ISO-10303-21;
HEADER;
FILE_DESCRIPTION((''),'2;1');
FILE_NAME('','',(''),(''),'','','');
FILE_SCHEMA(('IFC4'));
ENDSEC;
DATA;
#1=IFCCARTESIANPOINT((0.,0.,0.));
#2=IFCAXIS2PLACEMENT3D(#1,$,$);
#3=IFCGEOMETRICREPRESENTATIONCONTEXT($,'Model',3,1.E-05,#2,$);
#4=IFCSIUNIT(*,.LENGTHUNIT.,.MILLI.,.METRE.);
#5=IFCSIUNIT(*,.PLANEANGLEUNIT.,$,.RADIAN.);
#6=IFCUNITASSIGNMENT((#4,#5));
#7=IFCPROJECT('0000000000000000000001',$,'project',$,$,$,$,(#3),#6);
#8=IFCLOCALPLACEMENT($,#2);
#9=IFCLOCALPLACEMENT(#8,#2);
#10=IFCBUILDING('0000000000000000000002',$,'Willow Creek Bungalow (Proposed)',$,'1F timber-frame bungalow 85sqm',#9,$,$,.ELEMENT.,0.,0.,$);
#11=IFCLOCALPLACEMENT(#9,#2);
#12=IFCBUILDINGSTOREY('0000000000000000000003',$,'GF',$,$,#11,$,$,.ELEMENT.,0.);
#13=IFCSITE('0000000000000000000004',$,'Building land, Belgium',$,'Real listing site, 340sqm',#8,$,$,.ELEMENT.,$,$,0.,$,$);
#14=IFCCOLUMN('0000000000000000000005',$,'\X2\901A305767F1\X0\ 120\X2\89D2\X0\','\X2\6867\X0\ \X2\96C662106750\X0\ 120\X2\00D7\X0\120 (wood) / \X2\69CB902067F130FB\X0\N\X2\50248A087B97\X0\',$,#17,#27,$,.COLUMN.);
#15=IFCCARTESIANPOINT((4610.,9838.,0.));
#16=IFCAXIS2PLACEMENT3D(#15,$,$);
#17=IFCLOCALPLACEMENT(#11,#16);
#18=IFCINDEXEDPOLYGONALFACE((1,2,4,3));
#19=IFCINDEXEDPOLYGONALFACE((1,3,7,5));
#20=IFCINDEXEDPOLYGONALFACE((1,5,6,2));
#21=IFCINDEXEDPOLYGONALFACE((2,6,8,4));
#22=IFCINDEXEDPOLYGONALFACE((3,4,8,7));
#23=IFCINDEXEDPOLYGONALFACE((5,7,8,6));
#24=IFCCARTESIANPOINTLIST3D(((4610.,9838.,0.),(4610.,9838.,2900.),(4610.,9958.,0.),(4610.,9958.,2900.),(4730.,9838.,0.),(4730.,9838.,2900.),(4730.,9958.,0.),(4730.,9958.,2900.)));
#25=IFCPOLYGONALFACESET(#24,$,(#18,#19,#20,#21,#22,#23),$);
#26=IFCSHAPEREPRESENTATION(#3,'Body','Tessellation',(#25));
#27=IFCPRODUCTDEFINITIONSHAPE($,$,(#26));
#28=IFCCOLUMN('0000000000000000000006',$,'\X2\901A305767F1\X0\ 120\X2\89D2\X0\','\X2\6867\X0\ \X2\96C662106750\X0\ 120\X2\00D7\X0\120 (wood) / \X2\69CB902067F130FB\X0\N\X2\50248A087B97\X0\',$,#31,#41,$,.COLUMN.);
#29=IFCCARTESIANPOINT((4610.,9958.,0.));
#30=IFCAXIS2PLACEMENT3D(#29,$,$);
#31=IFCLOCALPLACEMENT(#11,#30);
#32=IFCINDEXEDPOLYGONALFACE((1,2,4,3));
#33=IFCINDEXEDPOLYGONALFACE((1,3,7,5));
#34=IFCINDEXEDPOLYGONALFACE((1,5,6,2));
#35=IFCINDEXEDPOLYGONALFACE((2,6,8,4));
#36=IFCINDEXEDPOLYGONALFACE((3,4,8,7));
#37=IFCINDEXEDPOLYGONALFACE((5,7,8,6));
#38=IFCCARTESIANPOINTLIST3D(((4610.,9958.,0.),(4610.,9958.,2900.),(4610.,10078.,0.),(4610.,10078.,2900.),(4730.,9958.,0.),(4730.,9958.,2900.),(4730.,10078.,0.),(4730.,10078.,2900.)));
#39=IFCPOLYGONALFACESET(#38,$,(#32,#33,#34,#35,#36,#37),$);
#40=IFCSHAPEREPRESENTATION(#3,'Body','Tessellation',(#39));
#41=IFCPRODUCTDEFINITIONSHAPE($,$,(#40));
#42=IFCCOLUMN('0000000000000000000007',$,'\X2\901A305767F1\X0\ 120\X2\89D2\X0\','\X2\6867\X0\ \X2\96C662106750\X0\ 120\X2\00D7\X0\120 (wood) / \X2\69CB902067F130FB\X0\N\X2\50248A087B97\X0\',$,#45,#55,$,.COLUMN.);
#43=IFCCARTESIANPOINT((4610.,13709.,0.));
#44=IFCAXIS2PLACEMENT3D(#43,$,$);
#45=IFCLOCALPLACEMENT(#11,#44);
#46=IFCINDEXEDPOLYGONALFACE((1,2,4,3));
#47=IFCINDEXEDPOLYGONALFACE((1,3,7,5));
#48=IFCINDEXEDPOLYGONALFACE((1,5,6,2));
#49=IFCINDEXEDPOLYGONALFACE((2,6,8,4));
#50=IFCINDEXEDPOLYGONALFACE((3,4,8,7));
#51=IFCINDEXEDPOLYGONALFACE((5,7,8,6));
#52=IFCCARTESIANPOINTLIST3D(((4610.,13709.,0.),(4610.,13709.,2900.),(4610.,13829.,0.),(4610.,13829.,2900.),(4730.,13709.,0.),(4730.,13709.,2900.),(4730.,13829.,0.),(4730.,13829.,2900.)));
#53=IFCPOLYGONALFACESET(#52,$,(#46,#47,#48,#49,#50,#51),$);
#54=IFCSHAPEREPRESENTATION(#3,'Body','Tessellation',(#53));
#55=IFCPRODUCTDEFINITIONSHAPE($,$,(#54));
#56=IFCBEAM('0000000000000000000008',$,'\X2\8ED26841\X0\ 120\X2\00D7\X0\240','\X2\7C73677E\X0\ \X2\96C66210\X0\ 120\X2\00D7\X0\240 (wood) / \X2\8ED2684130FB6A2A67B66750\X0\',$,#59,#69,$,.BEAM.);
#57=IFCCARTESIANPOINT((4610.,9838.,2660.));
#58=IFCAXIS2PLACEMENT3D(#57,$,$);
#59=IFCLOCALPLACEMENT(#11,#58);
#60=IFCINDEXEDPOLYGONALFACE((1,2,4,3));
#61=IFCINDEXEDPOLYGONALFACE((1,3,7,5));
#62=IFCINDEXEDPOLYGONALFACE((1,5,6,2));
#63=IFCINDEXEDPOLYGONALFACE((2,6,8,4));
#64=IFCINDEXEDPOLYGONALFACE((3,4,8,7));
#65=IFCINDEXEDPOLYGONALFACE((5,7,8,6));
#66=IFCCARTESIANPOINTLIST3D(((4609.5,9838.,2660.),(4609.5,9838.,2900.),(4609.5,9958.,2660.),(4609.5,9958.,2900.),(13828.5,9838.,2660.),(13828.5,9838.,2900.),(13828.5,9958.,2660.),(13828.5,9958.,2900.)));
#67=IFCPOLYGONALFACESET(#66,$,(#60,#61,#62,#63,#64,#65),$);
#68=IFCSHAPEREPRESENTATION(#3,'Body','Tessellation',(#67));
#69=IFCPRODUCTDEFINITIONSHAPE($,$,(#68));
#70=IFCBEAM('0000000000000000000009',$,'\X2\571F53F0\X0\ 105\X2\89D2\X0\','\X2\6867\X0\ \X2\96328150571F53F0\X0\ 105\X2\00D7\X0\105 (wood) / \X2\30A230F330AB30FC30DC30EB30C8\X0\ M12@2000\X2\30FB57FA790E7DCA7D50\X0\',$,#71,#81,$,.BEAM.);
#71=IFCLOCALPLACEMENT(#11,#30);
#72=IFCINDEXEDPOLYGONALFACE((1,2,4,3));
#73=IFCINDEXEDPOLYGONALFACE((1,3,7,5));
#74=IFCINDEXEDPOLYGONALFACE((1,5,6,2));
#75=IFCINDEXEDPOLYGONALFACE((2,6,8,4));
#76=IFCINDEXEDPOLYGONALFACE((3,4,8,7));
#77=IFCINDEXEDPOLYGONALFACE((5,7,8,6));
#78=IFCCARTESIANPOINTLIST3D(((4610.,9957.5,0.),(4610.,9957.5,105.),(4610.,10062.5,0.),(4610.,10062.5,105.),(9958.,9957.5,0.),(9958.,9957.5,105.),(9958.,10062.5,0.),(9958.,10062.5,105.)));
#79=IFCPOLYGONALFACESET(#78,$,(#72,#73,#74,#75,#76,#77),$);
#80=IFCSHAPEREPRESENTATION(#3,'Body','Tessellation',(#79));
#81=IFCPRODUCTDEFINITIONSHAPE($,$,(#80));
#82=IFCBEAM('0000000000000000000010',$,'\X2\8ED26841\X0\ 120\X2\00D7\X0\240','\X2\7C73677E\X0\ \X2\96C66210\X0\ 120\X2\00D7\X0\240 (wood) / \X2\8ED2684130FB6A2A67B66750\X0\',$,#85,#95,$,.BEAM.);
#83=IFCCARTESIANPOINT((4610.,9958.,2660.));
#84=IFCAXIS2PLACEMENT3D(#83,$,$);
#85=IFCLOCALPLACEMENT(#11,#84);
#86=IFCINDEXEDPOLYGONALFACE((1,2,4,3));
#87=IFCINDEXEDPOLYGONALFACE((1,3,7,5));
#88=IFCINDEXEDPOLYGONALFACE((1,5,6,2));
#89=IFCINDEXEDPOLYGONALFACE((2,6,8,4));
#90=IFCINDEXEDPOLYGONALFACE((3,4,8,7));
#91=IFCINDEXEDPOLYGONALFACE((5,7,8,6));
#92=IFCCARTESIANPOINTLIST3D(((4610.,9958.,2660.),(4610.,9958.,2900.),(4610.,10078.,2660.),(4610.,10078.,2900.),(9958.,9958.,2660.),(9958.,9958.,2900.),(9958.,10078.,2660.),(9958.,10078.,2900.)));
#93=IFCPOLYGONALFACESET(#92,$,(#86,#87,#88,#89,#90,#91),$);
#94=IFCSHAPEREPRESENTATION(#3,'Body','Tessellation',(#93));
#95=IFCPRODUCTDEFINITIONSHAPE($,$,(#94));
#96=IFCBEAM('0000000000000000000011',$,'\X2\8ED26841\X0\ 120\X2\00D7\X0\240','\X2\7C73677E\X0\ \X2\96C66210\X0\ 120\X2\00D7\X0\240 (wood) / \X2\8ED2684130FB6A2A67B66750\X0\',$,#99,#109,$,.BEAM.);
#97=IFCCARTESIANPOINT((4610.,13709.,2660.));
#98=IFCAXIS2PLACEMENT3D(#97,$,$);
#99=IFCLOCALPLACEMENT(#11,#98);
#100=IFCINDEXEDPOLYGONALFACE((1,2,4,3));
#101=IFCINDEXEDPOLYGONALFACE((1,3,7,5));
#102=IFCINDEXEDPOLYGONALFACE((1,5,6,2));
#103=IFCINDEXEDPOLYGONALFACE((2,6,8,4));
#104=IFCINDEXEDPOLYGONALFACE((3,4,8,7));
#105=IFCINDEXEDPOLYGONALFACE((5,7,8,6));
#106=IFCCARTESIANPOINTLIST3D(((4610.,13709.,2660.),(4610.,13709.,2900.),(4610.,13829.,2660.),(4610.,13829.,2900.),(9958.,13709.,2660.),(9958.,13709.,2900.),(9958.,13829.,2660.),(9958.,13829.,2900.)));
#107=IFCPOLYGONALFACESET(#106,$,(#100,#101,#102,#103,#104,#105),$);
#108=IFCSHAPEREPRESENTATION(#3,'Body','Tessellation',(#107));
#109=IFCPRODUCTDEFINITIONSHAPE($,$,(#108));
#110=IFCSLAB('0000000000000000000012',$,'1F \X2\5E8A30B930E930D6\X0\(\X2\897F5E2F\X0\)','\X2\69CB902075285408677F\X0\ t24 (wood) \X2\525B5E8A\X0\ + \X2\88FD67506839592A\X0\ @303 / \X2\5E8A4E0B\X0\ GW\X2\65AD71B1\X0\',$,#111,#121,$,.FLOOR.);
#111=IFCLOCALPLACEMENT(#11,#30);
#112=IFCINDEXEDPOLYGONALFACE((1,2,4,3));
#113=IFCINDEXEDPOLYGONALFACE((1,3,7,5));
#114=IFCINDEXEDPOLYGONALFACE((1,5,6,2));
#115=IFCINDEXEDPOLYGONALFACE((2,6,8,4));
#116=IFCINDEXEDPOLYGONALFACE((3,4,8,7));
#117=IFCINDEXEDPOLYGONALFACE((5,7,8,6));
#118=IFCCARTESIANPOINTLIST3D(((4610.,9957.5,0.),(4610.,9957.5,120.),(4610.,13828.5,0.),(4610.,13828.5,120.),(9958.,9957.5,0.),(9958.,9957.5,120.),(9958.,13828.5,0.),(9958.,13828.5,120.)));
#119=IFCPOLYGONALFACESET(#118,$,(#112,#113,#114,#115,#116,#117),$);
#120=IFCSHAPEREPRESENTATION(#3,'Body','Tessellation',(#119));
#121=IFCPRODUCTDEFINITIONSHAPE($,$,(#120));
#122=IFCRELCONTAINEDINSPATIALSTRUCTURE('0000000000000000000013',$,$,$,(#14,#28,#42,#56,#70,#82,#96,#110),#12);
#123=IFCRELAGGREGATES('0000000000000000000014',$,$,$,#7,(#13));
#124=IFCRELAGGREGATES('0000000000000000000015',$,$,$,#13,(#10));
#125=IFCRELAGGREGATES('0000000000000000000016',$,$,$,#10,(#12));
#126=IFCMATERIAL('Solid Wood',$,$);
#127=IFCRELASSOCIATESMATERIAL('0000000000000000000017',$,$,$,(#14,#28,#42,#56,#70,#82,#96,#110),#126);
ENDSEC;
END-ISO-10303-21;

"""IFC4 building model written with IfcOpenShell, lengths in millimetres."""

from ifc_helpers import new_model, si_unit, frame, frame_2d, origin, place, context, project, spatial, rectangle, extrude, material, element, save


model = new_model("IFC4")

# Units and contexts
model_context = context("Model", 3, precision=1e-05, world=origin())
ifc_project = project(units=[si_unit("LENGTHUNIT", "METRE", prefix="MILLI"), si_unit("PLANEANGLEUNIT", "RADIAN")], contexts=[model_context])

# Site, building, storey
site_placement = place(None, origin())
site = spatial("IfcSite", under=ifc_project, at=site_placement, Name="Building land, Belgium", ObjectType="Real listing site, 340sqm", CompositionType="ELEMENT", RefElevation=0.0)
building_placement = place(site_placement, origin())
building = spatial("IfcBuilding", under=site, at=building_placement, Name="Willow Creek Bungalow (Proposed)", ObjectType="1F timber-frame bungalow 85sqm", CompositionType="ELEMENT", ElevationOfRefHeight=0.0, ElevationOfTerrain=0.0)
storey_placement = place(building_placement, origin())
storey = spatial("IfcBuildingStorey", under=building, at=storey_placement, Name="GF", CompositionType="ELEMENT", Elevation=0.0)

# Columns
ifc_material_1 = material(Name="Solid Wood")
column_1_placement = place(storey_placement, frame((4610.0, 9838.0, 0.0)))
element("IfcColumn", 1, at=column_1_placement, inside=storey, material=ifc_material_1, Name="通し柱 120角", Description="桧 集成材 120×120 (wood) / 構造柱・N値計算", PredefinedType="COLUMN", context=model_context, shape_type="SweptSolid", body=[
    extrude(rectangle(XDim=120.0, YDim=120.0, at=frame_2d((60.0, 60.0))), frame((4610.0, 9838.0, 0.0)), (0.0, 0.0, 1.0), 2900.0),
])
column_2_placement = place(storey_placement, frame((4610.0, 9958.0, 0.0)))
element("IfcColumn", 2, at=column_2_placement, inside=storey, material=ifc_material_1, Name="通し柱 120角", Description="桧 集成材 120×120 (wood) / 構造柱・N値計算", PredefinedType="COLUMN", context=model_context, shape_type="SweptSolid", body=[
    extrude(rectangle(XDim=120.0, YDim=120.0, at=frame_2d((60.0, 60.0))), frame((4610.0, 9958.0, 0.0)), (0.0, 0.0, 1.0), 2900.0),
])
column_3_placement = place(storey_placement, frame((4610.0, 13709.0, 0.0)))
element("IfcColumn", 3, at=column_3_placement, inside=storey, material=ifc_material_1, Name="通し柱 120角", Description="桧 集成材 120×120 (wood) / 構造柱・N値計算", PredefinedType="COLUMN", context=model_context, shape_type="SweptSolid", body=[
    extrude(rectangle(XDim=120.0, YDim=120.0, at=frame_2d((60.0, 60.0))), frame((4610.0, 13709.0, 0.0)), (0.0, 0.0, 1.0), 2900.0),
])

# Beams
beam_1_placement = place(storey_placement, frame((4610.0, 9838.0, 2660.0)))
element("IfcBeam", 4, at=beam_1_placement, inside=storey, material=ifc_material_1, Name="軒桁 120×240", Description="米松 集成 120×240 (wood) / 軒桁・横架材", PredefinedType="BEAM", context=model_context, shape_type="SweptSolid", body=[
    extrude(rectangle(XDim=9219.0, YDim=120.0, at=frame_2d((4609.0, 60.0))), frame((4610.0, 9838.0, 2660.0)), (0.0, 0.0, 1.0), 240.0),
])
beam_2_placement = place(storey_placement, frame((4610.0, 9958.0, 0.0)))
element("IfcBeam", 5, at=beam_2_placement, inside=storey, material=ifc_material_1, Name="土台 105角", Description="桧 防腐土台 105×105 (wood) / アンカーボルト M12@2000・基礎緊結", PredefinedType="BEAM", context=model_context, shape_type="SweptSolid", body=[
    extrude(rectangle(XDim=5348.0, YDim=105.0, at=frame_2d((2674.0, 52.0))), frame((4610.0, 9958.0, 0.0)), (0.0, 0.0, 1.0), 105.0),
])
beam_3_placement = place(storey_placement, frame((4610.0, 9958.0, 2660.0)))
element("IfcBeam", 6, at=beam_3_placement, inside=storey, material=ifc_material_1, Name="軒桁 120×240", Description="米松 集成 120×240 (wood) / 軒桁・横架材", PredefinedType="BEAM", context=model_context, shape_type="SweptSolid", body=[
    extrude(rectangle(XDim=5348.0, YDim=120.0, at=frame_2d((2674.0, 60.0))), frame((4610.0, 9958.0, 2660.0)), (0.0, 0.0, 1.0), 240.0),
])
beam_4_placement = place(storey_placement, frame((4610.0, 13709.0, 2660.0)))
element("IfcBeam", 7, at=beam_4_placement, inside=storey, material=ifc_material_1, Name="軒桁 120×240", Description="米松 集成 120×240 (wood) / 軒桁・横架材", PredefinedType="BEAM", context=model_context, shape_type="SweptSolid", body=[
    extrude(rectangle(XDim=5348.0, YDim=120.0, at=frame_2d((2674.0, 60.0))), frame((4610.0, 13709.0, 2660.0)), (0.0, 0.0, 1.0), 240.0),
])

# Slab
slab_placement = place(storey_placement, frame((4610.0, 9958.0, 0.0)))
element("IfcSlab", 8, at=slab_placement, inside=storey, material=ifc_material_1, Name="1F 床スラブ(西帯)", Description="構造用合板 t24 (wood) 剛床 + 製材根太 @303 / 床下 GW断熱", PredefinedType="FLOOR", context=model_context, shape_type="SweptSolid", body=[
    extrude(rectangle(XDim=5348.0, YDim=3871.0, at=frame_2d((2674.0, 1935.0))), frame((4610.0, 9958.0, 0.0)), (0.0, 0.0, 1.0), 120.0),
])

save(model, "model.ifc")
